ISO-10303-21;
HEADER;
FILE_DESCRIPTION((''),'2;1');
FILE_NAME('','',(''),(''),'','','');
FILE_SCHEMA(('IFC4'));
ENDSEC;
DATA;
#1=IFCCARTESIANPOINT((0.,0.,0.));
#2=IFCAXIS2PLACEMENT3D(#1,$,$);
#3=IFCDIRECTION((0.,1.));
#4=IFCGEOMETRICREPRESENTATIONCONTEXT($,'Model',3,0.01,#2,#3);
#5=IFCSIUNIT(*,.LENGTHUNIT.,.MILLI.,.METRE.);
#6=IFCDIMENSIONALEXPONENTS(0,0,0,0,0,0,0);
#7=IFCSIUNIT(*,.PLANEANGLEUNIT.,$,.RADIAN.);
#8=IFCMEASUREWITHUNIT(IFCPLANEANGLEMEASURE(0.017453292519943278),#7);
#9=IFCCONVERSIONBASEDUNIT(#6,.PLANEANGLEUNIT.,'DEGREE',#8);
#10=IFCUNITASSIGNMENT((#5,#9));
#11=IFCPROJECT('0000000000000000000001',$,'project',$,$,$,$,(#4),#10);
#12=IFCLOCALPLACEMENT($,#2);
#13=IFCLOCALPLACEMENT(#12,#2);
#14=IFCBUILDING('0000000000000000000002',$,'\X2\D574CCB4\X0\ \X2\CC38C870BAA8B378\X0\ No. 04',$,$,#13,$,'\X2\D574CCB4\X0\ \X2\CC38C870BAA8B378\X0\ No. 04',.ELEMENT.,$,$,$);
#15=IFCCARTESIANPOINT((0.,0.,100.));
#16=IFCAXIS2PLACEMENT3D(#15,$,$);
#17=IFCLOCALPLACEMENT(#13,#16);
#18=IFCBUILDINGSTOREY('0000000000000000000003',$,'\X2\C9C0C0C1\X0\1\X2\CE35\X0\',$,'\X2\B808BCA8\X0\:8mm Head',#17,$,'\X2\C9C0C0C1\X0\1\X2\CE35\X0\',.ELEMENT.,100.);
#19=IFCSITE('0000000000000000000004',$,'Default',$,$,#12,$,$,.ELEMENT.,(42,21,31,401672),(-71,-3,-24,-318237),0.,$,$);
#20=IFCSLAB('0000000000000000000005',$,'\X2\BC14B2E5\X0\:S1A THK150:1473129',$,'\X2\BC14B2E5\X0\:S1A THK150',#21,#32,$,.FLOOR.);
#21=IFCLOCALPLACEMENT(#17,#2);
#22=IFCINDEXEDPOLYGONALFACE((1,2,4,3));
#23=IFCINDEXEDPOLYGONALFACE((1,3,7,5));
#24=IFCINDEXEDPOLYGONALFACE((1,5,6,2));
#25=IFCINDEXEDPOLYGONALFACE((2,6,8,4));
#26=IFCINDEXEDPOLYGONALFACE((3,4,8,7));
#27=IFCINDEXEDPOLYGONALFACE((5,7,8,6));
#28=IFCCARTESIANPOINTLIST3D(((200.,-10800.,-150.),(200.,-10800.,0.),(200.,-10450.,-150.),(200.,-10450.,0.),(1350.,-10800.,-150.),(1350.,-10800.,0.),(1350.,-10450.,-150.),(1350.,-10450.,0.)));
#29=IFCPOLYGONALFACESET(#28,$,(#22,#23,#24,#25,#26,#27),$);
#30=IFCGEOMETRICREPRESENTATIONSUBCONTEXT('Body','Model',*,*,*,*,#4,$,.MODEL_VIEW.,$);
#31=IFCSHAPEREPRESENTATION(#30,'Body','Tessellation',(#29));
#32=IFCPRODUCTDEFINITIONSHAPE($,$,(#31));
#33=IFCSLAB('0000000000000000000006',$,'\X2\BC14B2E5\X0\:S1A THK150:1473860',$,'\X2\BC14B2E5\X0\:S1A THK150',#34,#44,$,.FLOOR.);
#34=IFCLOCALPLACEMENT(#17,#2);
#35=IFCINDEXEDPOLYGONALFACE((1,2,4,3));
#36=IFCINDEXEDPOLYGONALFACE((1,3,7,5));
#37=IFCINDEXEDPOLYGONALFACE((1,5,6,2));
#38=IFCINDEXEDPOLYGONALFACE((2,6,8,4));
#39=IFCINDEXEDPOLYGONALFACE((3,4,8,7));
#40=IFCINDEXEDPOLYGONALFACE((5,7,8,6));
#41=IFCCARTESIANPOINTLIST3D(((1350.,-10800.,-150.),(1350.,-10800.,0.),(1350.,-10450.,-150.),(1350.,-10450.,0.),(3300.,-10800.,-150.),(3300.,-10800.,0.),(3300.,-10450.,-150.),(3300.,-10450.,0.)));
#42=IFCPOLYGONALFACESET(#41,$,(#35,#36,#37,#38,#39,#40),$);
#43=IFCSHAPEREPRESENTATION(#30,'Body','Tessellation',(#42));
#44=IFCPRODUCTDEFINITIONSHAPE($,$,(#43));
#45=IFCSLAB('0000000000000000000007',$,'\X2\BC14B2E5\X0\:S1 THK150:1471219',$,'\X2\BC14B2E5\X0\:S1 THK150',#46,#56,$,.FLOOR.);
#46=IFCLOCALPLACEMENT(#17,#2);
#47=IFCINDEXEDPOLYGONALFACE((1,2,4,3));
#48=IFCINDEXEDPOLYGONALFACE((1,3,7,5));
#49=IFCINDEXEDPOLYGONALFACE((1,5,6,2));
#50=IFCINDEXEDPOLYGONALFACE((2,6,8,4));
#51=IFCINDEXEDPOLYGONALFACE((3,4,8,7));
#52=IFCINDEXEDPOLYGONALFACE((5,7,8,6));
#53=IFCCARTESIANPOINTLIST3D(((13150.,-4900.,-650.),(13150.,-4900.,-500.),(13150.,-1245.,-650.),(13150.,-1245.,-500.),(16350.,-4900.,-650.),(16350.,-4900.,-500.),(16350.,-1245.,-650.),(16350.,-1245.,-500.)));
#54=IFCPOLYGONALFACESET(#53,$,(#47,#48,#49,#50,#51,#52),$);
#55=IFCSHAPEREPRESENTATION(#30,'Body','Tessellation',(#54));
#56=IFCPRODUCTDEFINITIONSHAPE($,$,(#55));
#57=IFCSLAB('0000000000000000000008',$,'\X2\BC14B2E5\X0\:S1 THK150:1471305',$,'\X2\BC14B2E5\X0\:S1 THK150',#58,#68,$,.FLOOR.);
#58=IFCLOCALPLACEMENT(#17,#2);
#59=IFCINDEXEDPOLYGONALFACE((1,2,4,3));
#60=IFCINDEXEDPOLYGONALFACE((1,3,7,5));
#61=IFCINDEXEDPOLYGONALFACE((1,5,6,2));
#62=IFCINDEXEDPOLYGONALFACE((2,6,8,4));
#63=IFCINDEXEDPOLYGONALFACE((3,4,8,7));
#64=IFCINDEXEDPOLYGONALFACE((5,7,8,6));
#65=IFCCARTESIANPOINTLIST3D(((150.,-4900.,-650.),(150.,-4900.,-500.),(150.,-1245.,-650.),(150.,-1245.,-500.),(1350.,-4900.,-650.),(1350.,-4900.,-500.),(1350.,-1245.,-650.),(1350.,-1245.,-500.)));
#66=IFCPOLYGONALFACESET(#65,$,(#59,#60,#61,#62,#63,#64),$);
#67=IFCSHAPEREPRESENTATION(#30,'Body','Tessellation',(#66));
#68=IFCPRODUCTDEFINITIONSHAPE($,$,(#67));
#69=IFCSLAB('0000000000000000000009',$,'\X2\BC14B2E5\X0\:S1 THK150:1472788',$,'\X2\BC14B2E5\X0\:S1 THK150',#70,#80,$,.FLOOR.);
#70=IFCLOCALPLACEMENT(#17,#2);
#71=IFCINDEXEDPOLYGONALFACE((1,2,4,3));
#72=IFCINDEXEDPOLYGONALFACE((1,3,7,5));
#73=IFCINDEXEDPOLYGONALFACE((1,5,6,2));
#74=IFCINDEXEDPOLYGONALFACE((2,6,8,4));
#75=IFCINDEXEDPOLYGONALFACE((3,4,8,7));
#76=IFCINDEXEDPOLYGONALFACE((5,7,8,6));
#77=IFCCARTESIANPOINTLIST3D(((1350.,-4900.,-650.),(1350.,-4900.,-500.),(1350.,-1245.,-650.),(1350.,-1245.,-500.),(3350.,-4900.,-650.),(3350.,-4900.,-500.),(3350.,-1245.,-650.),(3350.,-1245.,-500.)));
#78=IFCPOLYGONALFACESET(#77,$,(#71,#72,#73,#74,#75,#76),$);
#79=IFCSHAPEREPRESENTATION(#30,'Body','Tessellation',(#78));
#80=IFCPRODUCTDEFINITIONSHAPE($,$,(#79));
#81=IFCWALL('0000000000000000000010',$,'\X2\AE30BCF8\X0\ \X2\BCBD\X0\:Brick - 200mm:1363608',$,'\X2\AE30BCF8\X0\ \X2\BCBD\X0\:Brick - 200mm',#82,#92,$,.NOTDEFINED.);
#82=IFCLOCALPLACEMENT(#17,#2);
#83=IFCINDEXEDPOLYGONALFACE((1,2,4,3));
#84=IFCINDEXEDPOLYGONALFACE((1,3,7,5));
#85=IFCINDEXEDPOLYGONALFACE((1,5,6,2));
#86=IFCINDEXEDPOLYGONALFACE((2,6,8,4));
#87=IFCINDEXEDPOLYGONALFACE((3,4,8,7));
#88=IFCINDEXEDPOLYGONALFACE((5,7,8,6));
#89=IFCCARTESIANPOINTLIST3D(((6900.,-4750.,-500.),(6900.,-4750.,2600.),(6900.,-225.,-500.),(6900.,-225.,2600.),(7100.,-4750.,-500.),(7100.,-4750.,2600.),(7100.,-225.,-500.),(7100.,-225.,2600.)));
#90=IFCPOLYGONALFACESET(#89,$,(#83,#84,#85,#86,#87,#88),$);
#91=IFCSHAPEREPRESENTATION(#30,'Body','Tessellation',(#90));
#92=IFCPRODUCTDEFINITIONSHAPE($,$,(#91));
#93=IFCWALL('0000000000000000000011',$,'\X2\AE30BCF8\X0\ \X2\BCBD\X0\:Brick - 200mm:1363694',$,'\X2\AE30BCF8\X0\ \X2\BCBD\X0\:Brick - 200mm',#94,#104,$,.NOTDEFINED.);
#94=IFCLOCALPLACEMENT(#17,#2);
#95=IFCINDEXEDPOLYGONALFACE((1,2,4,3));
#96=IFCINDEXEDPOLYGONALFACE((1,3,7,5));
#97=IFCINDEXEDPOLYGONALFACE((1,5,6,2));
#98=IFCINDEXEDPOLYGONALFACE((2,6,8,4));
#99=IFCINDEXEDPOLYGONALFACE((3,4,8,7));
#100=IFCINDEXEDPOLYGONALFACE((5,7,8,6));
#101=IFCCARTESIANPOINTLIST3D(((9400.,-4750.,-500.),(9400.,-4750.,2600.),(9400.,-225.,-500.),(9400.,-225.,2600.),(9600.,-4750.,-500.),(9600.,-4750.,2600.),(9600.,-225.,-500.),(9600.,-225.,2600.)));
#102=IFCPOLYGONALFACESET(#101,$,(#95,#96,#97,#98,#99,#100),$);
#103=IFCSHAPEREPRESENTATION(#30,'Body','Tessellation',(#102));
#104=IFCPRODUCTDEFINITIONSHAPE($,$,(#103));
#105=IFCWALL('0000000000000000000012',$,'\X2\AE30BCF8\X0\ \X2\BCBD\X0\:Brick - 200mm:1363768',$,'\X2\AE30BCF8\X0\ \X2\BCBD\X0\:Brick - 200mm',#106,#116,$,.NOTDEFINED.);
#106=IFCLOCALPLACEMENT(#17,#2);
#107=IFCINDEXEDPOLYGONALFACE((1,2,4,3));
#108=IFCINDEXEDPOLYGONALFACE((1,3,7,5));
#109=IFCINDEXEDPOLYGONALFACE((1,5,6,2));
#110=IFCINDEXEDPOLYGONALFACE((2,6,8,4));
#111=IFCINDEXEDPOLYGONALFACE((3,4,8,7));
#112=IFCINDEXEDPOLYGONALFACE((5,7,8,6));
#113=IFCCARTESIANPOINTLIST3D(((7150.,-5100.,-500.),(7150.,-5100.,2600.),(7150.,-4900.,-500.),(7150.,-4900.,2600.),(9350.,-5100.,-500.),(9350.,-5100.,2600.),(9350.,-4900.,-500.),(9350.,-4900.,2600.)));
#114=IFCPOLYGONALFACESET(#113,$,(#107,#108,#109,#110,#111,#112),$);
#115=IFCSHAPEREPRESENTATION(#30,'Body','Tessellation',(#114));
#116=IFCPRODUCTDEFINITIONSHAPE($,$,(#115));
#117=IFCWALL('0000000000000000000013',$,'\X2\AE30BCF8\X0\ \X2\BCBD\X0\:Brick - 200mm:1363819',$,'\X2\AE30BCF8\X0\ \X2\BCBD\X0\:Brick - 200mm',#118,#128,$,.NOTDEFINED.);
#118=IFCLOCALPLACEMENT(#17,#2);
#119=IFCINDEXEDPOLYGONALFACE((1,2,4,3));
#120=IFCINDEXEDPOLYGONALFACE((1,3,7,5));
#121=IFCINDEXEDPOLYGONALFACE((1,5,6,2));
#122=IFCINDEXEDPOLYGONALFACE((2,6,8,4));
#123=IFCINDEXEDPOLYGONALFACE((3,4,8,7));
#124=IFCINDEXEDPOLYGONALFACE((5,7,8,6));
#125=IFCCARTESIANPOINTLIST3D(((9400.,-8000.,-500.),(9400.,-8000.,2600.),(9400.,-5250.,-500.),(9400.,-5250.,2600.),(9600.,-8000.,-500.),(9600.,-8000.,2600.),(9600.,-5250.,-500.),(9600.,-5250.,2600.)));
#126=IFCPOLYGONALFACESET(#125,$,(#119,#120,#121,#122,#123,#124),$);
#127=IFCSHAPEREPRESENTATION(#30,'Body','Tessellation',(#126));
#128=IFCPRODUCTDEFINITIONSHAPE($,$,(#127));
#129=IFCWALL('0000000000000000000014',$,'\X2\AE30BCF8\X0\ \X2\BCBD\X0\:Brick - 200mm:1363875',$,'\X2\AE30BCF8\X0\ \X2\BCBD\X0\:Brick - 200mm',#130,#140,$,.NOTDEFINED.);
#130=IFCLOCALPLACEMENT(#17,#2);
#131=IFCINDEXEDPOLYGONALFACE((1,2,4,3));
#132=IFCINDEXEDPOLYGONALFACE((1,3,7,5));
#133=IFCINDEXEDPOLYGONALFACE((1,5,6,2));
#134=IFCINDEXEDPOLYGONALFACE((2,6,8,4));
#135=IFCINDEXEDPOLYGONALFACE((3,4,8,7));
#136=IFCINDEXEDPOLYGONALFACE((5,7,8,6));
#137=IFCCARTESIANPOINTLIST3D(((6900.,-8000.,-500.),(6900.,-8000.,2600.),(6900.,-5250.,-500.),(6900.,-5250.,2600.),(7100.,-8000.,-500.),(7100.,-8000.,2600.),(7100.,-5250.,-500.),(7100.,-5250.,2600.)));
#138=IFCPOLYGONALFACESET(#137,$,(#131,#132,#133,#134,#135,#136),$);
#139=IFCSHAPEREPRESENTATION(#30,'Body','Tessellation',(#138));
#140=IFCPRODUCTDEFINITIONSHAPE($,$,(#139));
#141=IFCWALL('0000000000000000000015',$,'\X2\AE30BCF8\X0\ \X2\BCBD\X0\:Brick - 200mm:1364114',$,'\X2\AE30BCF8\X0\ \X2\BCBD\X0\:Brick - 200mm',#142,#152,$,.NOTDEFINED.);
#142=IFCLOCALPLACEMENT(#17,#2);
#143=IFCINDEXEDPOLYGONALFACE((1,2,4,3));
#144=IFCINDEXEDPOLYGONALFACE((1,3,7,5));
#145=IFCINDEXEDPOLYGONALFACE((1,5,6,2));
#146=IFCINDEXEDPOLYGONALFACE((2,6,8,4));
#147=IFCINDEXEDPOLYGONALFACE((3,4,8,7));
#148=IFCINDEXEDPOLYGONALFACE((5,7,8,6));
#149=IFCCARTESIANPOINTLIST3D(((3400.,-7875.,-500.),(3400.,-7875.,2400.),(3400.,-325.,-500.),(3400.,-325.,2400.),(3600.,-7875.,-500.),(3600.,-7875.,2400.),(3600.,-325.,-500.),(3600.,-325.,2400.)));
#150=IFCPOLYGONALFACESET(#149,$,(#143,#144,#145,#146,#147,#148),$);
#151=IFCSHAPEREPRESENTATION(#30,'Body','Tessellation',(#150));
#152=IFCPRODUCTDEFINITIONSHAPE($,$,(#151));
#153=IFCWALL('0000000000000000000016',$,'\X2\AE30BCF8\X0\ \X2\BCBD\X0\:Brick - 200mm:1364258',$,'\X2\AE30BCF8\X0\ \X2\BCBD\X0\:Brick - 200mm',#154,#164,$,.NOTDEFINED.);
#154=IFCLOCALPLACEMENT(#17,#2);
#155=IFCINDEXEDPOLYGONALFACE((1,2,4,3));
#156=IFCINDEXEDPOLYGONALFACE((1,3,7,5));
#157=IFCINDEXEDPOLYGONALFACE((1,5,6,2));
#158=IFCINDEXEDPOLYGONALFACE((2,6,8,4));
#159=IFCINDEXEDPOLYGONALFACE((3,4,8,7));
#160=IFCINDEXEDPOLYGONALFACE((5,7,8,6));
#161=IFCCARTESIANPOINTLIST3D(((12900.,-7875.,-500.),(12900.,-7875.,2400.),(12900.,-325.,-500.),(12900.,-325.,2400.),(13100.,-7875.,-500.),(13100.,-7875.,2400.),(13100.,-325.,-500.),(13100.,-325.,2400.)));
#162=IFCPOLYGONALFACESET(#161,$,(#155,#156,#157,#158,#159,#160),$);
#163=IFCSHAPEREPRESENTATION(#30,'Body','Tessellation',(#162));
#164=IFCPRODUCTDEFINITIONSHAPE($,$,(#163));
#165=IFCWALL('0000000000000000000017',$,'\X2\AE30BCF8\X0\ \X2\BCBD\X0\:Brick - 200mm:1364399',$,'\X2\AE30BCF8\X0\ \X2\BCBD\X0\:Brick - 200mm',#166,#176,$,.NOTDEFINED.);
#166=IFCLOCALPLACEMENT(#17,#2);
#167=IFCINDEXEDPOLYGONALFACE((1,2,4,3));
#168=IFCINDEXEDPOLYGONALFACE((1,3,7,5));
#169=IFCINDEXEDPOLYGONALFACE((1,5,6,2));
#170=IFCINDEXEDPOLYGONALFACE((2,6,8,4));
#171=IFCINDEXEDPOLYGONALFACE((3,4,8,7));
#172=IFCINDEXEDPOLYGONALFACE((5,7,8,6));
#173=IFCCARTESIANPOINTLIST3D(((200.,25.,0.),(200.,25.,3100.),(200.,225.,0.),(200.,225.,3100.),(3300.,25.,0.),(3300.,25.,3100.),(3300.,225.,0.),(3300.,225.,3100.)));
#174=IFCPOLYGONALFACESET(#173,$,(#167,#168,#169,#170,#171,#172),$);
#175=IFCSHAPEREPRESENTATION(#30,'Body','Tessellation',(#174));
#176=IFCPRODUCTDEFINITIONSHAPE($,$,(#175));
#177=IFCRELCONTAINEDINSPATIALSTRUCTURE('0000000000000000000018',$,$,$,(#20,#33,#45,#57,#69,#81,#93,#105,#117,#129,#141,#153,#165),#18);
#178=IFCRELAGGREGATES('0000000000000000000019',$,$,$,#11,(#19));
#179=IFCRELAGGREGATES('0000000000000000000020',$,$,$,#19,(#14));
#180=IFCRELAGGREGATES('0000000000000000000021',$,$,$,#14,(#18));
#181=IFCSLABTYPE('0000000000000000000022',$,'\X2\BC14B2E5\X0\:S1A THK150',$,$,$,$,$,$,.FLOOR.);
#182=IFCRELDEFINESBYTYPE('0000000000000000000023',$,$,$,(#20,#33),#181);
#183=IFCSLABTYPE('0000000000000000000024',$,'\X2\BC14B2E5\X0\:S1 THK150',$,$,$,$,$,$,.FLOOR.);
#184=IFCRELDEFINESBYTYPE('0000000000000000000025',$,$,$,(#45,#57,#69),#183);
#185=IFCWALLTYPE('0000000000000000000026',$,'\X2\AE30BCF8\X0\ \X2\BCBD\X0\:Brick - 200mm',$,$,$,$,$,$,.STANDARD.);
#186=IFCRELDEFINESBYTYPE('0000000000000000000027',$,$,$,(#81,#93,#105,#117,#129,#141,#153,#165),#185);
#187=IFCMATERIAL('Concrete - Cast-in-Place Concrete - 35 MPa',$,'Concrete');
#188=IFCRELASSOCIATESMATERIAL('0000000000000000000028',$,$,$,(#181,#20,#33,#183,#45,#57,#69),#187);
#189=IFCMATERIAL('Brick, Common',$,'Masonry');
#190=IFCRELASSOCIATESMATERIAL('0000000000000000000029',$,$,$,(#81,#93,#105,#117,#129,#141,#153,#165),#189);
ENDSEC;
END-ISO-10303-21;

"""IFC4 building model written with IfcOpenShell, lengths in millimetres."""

from ifc_helpers import new_model, entity, si_unit, converted_unit, direction, frame, origin, place, context, subcontext, project, spatial, indexed_curve, outline, extrude, material, type_object, element, save


model = new_model("IFC4")

# Units and contexts
model_context = context("Model", 3, precision=0.01, world=origin(), true_north=direction((0.0, 1.0)))
body_context = subcontext(model_context, "Body", "Model", "MODEL_VIEW")
ifc_project = project(units=[si_unit("LENGTHUNIT", "METRE", prefix="MILLI"), converted_unit("PLANEANGLEUNIT", "DEGREE", entity("IfcPlaneAngleMeasure", 0.017453292519943278), si_unit("PLANEANGLEUNIT", "RADIAN"), dimensions=[0, 0, 0, 0, 0, 0, 0])], contexts=[model_context])

# Site, building, storey
site_placement = place(None, origin())
site = spatial("IfcSite", under=ifc_project, at=site_placement, Name="Default", CompositionType="ELEMENT", RefLatitude=(42, 21, 31, 401672), RefLongitude=(-71, -3, -24, -318237), RefElevation=0.0)
building_placement = place(site_placement, origin())
building = spatial("IfcBuilding", under=site, at=building_placement, Name="해체 참조모델 No. 04", LongName="해체 참조모델 No. 04", CompositionType="ELEMENT")
storey_placement = place(building_placement, frame((0.0, 0.0, 100.0)))
storey = spatial("IfcBuildingStorey", under=building, at=storey_placement, Name="지상1층", ObjectType="레벨:8mm Head", LongName="지상1층", CompositionType="ELEMENT", Elevation=100.0)

# Slabs
ifc_material_1 = material(Name="Concrete - Cast-in-Place Concrete - 35 MPa", Category="Concrete")
slab_type_1 = type_object("IfcSlabType", Name="바닥:S1A THK150", PredefinedType="FLOOR", material=ifc_material_1)
slab_1_placement = place(storey_placement, origin())
element("IfcSlab", 1, at=slab_1_placement, inside=storey, type_object=slab_type_1, material=ifc_material_1, Name="바닥:S1A THK150:1473129", ObjectType="바닥:S1A THK150", PredefinedType="FLOOR", context=body_context, shape_type="SweptSolid", body=[
    extrude(outline(indexed_curve([(-175.0, -575.0), (175.0, -575.0), (175.0, 575.0), (-175.0, 575.0), (-175.0, -575.0)], self_intersect=False)), frame((775.0, -10625.0, 0.0), z_axis=(0.0, 0.0, -1.0), x_axis=(0.0, 1.0, 0.0)), (0.0, 0.0, 1.0), 150.0),
])
slab_2_placement = place(storey_placement, origin())
element("IfcSlab", 2, at=slab_2_placement, inside=storey, type_object=slab_type_1, material=ifc_material_1, Name="바닥:S1A THK150:1473860", ObjectType="바닥:S1A THK150", PredefinedType="FLOOR", context=body_context, shape_type="SweptSolid", body=[
    extrude(outline(indexed_curve([(-175.0, -975.0), (175.0, -975.0), (175.0, 975.0), (-175.0, 975.0), (-175.0, -975.0)], self_intersect=False)), frame((2325.0, -10625.0, 0.0), z_axis=(0.0, 0.0, -1.0), x_axis=(0.0, 1.0, 0.0)), (0.0, 0.0, 1.0), 150.0),
])
slab_type_2 = type_object("IfcSlabType", Name="바닥:S1 THK150", PredefinedType="FLOOR", material=ifc_material_1)
slab_3_placement = place(storey_placement, origin())
element("IfcSlab", 3, at=slab_3_placement, inside=storey, type_object=slab_type_2, material=ifc_material_1, Name="바닥:S1 THK150:1471219", ObjectType="바닥:S1 THK150", PredefinedType="FLOOR", context=body_context, shape_type="SweptSolid", body=[
    extrude(outline(indexed_curve([(-1827.5, -1600.0), (1827.5, -1600.0), (1827.5, 1600.0), (-1827.5, 1600.0), (-1827.5, -1600.0)], self_intersect=False)), frame((14750.0, -3072.5, -500.0), z_axis=(0.0, 0.0, -1.0), x_axis=(0.0, 1.0, 0.0)), (0.0, 0.0, 1.0), 150.0),
])
slab_4_placement = place(storey_placement, origin())
element("IfcSlab", 4, at=slab_4_placement, inside=storey, type_object=slab_type_2, material=ifc_material_1, Name="바닥:S1 THK150:1471305", ObjectType="바닥:S1 THK150", PredefinedType="FLOOR", context=body_context, shape_type="SweptSolid", body=[
    extrude(outline(indexed_curve([(-1827.5, -600.0), (1827.5, -600.0), (1827.5, 600.0), (-1827.5, 600.0), (-1827.5, -600.0)], self_intersect=False)), frame((750.0, -3072.5, -500.0), z_axis=(0.0, 0.0, -1.0), x_axis=(0.0, 1.0, 0.0)), (0.0, 0.0, 1.0), 150.0),
])
slab_5_placement = place(storey_placement, origin())
element("IfcSlab", 5, at=slab_5_placement, inside=storey, type_object=slab_type_2, material=ifc_material_1, Name="바닥:S1 THK150:1472788", ObjectType="바닥:S1 THK150", PredefinedType="FLOOR", context=body_context, shape_type="SweptSolid", body=[
    extrude(outline(indexed_curve([(-1827.5, -1000.0), (1827.5, -1000.0), (1827.5, 1000.0), (-1827.5, 1000.0), (-1827.5, -1000.0)], self_intersect=False)), frame((2350.0, -3072.5, -500.0), z_axis=(0.0, 0.0, -1.0), x_axis=(0.0, 1.0, 0.0)), (0.0, 0.0, 1.0), 150.0),
])

# Walls
ifc_material_2 = material(Name="Brick, Common", Category="Masonry")
wall_type = type_object("IfcWallType", Name="기본 벽:Brick - 200mm", PredefinedType="STANDARD")
wall_1_placement = place(storey_placement, frame((7000.0, -225.0, -500.0), z_axis=(0.0, 0.0, 1.0), x_axis=(0.0, -1.0, 0.0)))
element("IfcWall", 6, at=wall_1_placement, inside=storey, type_object=wall_type, material=ifc_material_2, Name="기본 벽:Brick - 200mm:1363608", ObjectType="기본 벽:Brick - 200mm", PredefinedType="NOTDEFINED", context=body_context, shape_type="SweptSolid", body=[
    extrude(outline(indexed_curve([(4525.0, 100.0), (0.0, 100.0), (0.0, -100.0), (4525.0, -100.0), (4525.0, 100.0)], self_intersect=False)), origin(), (0.0, 0.0, 1.0), 3100.0),
])
wall_2_placement = place(storey_placement, frame((9500.0, -225.0, -500.0), z_axis=(0.0, 0.0, 1.0), x_axis=(0.0, -1.0, 0.0)))
element("IfcWall", 7, at=wall_2_placement, inside=storey, type_object=wall_type, material=ifc_material_2, Name="기본 벽:Brick - 200mm:1363694", ObjectType="기본 벽:Brick - 200mm", PredefinedType="NOTDEFINED", context=body_context, shape_type="SweptSolid", body=[
    extrude(outline(indexed_curve([(4525.0, 100.0), (0.0, 100.0), (0.0, -100.0), (4525.0, -100.0), (4525.0, 100.0)], self_intersect=False)), origin(), (0.0, 0.0, 1.0), 3100.0),
])
wall_3_placement = place(storey_placement, frame((9350.0, -5000.0, -500.0), z_axis=(0.0, 0.0, 1.0), x_axis=(-1.0, 0.0, 0.0)))
element("IfcWall", 8, at=wall_3_placement, inside=storey, type_object=wall_type, material=ifc_material_2, Name="기본 벽:Brick - 200mm:1363768", ObjectType="기본 벽:Brick - 200mm", PredefinedType="NOTDEFINED", context=body_context, shape_type="SweptSolid", body=[
    extrude(outline(indexed_curve([(2200.0, 100.0), (0.0, 100.0), (0.0, -100.0), (2200.0, -100.0), (2200.0, 100.0)], self_intersect=False)), origin(), (0.0, 0.0, 1.0), 3100.0),
])
wall_4_placement = place(storey_placement, frame((9500.0, -5250.0, -500.0), z_axis=(0.0, 0.0, 1.0), x_axis=(0.0, -1.0, 0.0)))
element("IfcWall", 9, at=wall_4_placement, inside=storey, type_object=wall_type, material=ifc_material_2, Name="기본 벽:Brick - 200mm:1363819", ObjectType="기본 벽:Brick - 200mm", PredefinedType="NOTDEFINED", context=body_context, shape_type="SweptSolid", body=[
    extrude(outline(indexed_curve([(2750.0, 100.0), (0.0, 100.0), (0.0, -100.0), (2750.0, -100.0), (2750.0, 100.0)], self_intersect=False)), origin(), (0.0, 0.0, 1.0), 3100.0),
])
wall_5_placement = place(storey_placement, frame((7000.0, -5250.0, -500.0), z_axis=(0.0, 0.0, 1.0), x_axis=(0.0, -1.0, 0.0)))
element("IfcWall", 10, at=wall_5_placement, inside=storey, type_object=wall_type, material=ifc_material_2, Name="기본 벽:Brick - 200mm:1363875", ObjectType="기본 벽:Brick - 200mm", PredefinedType="NOTDEFINED", context=body_context, shape_type="SweptSolid", body=[
    extrude(outline(indexed_curve([(2750.0, 100.0), (0.0, 100.0), (0.0, -100.0), (2750.0, -100.0), (2750.0, 100.0)], self_intersect=False)), origin(), (0.0, 0.0, 1.0), 3100.0),
])
wall_6_placement = place(storey_placement, frame((3500.0, -7875.0, -500.0), z_axis=(0.0, 0.0, 1.0), x_axis=(0.0, 1.0, 0.0)))
element("IfcWall", 11, at=wall_6_placement, inside=storey, type_object=wall_type, material=ifc_material_2, Name="기본 벽:Brick - 200mm:1364114", ObjectType="기본 벽:Brick - 200mm", PredefinedType="NOTDEFINED", context=body_context, shape_type="SweptSolid", body=[
    extrude(outline(indexed_curve([(7550.0, 100.0), (0.0, 100.0), (0.0, -100.0), (7550.0, -100.0), (7550.0, 100.0)], self_intersect=False)), origin(), (0.0, 0.0, 1.0), 2900.0),
])
wall_7_placement = place(storey_placement, frame((13000.0, -325.0, -500.0), z_axis=(0.0, 0.0, 1.0), x_axis=(0.0, -1.0, 0.0)))
element("IfcWall", 12, at=wall_7_placement, inside=storey, type_object=wall_type, material=ifc_material_2, Name="기본 벽:Brick - 200mm:1364258", ObjectType="기본 벽:Brick - 200mm", PredefinedType="NOTDEFINED", context=body_context, shape_type="SweptSolid", body=[
    extrude(outline(indexed_curve([(7550.0, 100.0), (0.0, 100.0), (0.0, -100.0), (7550.0, -100.0), (7550.0, 100.0)], self_intersect=False)), origin(), (0.0, 0.0, 1.0), 2900.0),
])
wall_8_placement = place(storey_placement, frame((200.0, 125.0, 0.0)))
element("IfcWall", 13, at=wall_8_placement, inside=storey, type_object=wall_type, material=ifc_material_2, Name="기본 벽:Brick - 200mm:1364399", ObjectType="기본 벽:Brick - 200mm", PredefinedType="NOTDEFINED", context=body_context, shape_type="SweptSolid", body=[
    extrude(outline(indexed_curve([(3100.0, 100.0), (0.0, 100.0), (0.0, -100.0), (3100.0, -100.0), (3100.0, 100.0)], self_intersect=False)), origin(), (0.0, 0.0, 1.0), 3100.0),
])

save(model, "model.ifc")
